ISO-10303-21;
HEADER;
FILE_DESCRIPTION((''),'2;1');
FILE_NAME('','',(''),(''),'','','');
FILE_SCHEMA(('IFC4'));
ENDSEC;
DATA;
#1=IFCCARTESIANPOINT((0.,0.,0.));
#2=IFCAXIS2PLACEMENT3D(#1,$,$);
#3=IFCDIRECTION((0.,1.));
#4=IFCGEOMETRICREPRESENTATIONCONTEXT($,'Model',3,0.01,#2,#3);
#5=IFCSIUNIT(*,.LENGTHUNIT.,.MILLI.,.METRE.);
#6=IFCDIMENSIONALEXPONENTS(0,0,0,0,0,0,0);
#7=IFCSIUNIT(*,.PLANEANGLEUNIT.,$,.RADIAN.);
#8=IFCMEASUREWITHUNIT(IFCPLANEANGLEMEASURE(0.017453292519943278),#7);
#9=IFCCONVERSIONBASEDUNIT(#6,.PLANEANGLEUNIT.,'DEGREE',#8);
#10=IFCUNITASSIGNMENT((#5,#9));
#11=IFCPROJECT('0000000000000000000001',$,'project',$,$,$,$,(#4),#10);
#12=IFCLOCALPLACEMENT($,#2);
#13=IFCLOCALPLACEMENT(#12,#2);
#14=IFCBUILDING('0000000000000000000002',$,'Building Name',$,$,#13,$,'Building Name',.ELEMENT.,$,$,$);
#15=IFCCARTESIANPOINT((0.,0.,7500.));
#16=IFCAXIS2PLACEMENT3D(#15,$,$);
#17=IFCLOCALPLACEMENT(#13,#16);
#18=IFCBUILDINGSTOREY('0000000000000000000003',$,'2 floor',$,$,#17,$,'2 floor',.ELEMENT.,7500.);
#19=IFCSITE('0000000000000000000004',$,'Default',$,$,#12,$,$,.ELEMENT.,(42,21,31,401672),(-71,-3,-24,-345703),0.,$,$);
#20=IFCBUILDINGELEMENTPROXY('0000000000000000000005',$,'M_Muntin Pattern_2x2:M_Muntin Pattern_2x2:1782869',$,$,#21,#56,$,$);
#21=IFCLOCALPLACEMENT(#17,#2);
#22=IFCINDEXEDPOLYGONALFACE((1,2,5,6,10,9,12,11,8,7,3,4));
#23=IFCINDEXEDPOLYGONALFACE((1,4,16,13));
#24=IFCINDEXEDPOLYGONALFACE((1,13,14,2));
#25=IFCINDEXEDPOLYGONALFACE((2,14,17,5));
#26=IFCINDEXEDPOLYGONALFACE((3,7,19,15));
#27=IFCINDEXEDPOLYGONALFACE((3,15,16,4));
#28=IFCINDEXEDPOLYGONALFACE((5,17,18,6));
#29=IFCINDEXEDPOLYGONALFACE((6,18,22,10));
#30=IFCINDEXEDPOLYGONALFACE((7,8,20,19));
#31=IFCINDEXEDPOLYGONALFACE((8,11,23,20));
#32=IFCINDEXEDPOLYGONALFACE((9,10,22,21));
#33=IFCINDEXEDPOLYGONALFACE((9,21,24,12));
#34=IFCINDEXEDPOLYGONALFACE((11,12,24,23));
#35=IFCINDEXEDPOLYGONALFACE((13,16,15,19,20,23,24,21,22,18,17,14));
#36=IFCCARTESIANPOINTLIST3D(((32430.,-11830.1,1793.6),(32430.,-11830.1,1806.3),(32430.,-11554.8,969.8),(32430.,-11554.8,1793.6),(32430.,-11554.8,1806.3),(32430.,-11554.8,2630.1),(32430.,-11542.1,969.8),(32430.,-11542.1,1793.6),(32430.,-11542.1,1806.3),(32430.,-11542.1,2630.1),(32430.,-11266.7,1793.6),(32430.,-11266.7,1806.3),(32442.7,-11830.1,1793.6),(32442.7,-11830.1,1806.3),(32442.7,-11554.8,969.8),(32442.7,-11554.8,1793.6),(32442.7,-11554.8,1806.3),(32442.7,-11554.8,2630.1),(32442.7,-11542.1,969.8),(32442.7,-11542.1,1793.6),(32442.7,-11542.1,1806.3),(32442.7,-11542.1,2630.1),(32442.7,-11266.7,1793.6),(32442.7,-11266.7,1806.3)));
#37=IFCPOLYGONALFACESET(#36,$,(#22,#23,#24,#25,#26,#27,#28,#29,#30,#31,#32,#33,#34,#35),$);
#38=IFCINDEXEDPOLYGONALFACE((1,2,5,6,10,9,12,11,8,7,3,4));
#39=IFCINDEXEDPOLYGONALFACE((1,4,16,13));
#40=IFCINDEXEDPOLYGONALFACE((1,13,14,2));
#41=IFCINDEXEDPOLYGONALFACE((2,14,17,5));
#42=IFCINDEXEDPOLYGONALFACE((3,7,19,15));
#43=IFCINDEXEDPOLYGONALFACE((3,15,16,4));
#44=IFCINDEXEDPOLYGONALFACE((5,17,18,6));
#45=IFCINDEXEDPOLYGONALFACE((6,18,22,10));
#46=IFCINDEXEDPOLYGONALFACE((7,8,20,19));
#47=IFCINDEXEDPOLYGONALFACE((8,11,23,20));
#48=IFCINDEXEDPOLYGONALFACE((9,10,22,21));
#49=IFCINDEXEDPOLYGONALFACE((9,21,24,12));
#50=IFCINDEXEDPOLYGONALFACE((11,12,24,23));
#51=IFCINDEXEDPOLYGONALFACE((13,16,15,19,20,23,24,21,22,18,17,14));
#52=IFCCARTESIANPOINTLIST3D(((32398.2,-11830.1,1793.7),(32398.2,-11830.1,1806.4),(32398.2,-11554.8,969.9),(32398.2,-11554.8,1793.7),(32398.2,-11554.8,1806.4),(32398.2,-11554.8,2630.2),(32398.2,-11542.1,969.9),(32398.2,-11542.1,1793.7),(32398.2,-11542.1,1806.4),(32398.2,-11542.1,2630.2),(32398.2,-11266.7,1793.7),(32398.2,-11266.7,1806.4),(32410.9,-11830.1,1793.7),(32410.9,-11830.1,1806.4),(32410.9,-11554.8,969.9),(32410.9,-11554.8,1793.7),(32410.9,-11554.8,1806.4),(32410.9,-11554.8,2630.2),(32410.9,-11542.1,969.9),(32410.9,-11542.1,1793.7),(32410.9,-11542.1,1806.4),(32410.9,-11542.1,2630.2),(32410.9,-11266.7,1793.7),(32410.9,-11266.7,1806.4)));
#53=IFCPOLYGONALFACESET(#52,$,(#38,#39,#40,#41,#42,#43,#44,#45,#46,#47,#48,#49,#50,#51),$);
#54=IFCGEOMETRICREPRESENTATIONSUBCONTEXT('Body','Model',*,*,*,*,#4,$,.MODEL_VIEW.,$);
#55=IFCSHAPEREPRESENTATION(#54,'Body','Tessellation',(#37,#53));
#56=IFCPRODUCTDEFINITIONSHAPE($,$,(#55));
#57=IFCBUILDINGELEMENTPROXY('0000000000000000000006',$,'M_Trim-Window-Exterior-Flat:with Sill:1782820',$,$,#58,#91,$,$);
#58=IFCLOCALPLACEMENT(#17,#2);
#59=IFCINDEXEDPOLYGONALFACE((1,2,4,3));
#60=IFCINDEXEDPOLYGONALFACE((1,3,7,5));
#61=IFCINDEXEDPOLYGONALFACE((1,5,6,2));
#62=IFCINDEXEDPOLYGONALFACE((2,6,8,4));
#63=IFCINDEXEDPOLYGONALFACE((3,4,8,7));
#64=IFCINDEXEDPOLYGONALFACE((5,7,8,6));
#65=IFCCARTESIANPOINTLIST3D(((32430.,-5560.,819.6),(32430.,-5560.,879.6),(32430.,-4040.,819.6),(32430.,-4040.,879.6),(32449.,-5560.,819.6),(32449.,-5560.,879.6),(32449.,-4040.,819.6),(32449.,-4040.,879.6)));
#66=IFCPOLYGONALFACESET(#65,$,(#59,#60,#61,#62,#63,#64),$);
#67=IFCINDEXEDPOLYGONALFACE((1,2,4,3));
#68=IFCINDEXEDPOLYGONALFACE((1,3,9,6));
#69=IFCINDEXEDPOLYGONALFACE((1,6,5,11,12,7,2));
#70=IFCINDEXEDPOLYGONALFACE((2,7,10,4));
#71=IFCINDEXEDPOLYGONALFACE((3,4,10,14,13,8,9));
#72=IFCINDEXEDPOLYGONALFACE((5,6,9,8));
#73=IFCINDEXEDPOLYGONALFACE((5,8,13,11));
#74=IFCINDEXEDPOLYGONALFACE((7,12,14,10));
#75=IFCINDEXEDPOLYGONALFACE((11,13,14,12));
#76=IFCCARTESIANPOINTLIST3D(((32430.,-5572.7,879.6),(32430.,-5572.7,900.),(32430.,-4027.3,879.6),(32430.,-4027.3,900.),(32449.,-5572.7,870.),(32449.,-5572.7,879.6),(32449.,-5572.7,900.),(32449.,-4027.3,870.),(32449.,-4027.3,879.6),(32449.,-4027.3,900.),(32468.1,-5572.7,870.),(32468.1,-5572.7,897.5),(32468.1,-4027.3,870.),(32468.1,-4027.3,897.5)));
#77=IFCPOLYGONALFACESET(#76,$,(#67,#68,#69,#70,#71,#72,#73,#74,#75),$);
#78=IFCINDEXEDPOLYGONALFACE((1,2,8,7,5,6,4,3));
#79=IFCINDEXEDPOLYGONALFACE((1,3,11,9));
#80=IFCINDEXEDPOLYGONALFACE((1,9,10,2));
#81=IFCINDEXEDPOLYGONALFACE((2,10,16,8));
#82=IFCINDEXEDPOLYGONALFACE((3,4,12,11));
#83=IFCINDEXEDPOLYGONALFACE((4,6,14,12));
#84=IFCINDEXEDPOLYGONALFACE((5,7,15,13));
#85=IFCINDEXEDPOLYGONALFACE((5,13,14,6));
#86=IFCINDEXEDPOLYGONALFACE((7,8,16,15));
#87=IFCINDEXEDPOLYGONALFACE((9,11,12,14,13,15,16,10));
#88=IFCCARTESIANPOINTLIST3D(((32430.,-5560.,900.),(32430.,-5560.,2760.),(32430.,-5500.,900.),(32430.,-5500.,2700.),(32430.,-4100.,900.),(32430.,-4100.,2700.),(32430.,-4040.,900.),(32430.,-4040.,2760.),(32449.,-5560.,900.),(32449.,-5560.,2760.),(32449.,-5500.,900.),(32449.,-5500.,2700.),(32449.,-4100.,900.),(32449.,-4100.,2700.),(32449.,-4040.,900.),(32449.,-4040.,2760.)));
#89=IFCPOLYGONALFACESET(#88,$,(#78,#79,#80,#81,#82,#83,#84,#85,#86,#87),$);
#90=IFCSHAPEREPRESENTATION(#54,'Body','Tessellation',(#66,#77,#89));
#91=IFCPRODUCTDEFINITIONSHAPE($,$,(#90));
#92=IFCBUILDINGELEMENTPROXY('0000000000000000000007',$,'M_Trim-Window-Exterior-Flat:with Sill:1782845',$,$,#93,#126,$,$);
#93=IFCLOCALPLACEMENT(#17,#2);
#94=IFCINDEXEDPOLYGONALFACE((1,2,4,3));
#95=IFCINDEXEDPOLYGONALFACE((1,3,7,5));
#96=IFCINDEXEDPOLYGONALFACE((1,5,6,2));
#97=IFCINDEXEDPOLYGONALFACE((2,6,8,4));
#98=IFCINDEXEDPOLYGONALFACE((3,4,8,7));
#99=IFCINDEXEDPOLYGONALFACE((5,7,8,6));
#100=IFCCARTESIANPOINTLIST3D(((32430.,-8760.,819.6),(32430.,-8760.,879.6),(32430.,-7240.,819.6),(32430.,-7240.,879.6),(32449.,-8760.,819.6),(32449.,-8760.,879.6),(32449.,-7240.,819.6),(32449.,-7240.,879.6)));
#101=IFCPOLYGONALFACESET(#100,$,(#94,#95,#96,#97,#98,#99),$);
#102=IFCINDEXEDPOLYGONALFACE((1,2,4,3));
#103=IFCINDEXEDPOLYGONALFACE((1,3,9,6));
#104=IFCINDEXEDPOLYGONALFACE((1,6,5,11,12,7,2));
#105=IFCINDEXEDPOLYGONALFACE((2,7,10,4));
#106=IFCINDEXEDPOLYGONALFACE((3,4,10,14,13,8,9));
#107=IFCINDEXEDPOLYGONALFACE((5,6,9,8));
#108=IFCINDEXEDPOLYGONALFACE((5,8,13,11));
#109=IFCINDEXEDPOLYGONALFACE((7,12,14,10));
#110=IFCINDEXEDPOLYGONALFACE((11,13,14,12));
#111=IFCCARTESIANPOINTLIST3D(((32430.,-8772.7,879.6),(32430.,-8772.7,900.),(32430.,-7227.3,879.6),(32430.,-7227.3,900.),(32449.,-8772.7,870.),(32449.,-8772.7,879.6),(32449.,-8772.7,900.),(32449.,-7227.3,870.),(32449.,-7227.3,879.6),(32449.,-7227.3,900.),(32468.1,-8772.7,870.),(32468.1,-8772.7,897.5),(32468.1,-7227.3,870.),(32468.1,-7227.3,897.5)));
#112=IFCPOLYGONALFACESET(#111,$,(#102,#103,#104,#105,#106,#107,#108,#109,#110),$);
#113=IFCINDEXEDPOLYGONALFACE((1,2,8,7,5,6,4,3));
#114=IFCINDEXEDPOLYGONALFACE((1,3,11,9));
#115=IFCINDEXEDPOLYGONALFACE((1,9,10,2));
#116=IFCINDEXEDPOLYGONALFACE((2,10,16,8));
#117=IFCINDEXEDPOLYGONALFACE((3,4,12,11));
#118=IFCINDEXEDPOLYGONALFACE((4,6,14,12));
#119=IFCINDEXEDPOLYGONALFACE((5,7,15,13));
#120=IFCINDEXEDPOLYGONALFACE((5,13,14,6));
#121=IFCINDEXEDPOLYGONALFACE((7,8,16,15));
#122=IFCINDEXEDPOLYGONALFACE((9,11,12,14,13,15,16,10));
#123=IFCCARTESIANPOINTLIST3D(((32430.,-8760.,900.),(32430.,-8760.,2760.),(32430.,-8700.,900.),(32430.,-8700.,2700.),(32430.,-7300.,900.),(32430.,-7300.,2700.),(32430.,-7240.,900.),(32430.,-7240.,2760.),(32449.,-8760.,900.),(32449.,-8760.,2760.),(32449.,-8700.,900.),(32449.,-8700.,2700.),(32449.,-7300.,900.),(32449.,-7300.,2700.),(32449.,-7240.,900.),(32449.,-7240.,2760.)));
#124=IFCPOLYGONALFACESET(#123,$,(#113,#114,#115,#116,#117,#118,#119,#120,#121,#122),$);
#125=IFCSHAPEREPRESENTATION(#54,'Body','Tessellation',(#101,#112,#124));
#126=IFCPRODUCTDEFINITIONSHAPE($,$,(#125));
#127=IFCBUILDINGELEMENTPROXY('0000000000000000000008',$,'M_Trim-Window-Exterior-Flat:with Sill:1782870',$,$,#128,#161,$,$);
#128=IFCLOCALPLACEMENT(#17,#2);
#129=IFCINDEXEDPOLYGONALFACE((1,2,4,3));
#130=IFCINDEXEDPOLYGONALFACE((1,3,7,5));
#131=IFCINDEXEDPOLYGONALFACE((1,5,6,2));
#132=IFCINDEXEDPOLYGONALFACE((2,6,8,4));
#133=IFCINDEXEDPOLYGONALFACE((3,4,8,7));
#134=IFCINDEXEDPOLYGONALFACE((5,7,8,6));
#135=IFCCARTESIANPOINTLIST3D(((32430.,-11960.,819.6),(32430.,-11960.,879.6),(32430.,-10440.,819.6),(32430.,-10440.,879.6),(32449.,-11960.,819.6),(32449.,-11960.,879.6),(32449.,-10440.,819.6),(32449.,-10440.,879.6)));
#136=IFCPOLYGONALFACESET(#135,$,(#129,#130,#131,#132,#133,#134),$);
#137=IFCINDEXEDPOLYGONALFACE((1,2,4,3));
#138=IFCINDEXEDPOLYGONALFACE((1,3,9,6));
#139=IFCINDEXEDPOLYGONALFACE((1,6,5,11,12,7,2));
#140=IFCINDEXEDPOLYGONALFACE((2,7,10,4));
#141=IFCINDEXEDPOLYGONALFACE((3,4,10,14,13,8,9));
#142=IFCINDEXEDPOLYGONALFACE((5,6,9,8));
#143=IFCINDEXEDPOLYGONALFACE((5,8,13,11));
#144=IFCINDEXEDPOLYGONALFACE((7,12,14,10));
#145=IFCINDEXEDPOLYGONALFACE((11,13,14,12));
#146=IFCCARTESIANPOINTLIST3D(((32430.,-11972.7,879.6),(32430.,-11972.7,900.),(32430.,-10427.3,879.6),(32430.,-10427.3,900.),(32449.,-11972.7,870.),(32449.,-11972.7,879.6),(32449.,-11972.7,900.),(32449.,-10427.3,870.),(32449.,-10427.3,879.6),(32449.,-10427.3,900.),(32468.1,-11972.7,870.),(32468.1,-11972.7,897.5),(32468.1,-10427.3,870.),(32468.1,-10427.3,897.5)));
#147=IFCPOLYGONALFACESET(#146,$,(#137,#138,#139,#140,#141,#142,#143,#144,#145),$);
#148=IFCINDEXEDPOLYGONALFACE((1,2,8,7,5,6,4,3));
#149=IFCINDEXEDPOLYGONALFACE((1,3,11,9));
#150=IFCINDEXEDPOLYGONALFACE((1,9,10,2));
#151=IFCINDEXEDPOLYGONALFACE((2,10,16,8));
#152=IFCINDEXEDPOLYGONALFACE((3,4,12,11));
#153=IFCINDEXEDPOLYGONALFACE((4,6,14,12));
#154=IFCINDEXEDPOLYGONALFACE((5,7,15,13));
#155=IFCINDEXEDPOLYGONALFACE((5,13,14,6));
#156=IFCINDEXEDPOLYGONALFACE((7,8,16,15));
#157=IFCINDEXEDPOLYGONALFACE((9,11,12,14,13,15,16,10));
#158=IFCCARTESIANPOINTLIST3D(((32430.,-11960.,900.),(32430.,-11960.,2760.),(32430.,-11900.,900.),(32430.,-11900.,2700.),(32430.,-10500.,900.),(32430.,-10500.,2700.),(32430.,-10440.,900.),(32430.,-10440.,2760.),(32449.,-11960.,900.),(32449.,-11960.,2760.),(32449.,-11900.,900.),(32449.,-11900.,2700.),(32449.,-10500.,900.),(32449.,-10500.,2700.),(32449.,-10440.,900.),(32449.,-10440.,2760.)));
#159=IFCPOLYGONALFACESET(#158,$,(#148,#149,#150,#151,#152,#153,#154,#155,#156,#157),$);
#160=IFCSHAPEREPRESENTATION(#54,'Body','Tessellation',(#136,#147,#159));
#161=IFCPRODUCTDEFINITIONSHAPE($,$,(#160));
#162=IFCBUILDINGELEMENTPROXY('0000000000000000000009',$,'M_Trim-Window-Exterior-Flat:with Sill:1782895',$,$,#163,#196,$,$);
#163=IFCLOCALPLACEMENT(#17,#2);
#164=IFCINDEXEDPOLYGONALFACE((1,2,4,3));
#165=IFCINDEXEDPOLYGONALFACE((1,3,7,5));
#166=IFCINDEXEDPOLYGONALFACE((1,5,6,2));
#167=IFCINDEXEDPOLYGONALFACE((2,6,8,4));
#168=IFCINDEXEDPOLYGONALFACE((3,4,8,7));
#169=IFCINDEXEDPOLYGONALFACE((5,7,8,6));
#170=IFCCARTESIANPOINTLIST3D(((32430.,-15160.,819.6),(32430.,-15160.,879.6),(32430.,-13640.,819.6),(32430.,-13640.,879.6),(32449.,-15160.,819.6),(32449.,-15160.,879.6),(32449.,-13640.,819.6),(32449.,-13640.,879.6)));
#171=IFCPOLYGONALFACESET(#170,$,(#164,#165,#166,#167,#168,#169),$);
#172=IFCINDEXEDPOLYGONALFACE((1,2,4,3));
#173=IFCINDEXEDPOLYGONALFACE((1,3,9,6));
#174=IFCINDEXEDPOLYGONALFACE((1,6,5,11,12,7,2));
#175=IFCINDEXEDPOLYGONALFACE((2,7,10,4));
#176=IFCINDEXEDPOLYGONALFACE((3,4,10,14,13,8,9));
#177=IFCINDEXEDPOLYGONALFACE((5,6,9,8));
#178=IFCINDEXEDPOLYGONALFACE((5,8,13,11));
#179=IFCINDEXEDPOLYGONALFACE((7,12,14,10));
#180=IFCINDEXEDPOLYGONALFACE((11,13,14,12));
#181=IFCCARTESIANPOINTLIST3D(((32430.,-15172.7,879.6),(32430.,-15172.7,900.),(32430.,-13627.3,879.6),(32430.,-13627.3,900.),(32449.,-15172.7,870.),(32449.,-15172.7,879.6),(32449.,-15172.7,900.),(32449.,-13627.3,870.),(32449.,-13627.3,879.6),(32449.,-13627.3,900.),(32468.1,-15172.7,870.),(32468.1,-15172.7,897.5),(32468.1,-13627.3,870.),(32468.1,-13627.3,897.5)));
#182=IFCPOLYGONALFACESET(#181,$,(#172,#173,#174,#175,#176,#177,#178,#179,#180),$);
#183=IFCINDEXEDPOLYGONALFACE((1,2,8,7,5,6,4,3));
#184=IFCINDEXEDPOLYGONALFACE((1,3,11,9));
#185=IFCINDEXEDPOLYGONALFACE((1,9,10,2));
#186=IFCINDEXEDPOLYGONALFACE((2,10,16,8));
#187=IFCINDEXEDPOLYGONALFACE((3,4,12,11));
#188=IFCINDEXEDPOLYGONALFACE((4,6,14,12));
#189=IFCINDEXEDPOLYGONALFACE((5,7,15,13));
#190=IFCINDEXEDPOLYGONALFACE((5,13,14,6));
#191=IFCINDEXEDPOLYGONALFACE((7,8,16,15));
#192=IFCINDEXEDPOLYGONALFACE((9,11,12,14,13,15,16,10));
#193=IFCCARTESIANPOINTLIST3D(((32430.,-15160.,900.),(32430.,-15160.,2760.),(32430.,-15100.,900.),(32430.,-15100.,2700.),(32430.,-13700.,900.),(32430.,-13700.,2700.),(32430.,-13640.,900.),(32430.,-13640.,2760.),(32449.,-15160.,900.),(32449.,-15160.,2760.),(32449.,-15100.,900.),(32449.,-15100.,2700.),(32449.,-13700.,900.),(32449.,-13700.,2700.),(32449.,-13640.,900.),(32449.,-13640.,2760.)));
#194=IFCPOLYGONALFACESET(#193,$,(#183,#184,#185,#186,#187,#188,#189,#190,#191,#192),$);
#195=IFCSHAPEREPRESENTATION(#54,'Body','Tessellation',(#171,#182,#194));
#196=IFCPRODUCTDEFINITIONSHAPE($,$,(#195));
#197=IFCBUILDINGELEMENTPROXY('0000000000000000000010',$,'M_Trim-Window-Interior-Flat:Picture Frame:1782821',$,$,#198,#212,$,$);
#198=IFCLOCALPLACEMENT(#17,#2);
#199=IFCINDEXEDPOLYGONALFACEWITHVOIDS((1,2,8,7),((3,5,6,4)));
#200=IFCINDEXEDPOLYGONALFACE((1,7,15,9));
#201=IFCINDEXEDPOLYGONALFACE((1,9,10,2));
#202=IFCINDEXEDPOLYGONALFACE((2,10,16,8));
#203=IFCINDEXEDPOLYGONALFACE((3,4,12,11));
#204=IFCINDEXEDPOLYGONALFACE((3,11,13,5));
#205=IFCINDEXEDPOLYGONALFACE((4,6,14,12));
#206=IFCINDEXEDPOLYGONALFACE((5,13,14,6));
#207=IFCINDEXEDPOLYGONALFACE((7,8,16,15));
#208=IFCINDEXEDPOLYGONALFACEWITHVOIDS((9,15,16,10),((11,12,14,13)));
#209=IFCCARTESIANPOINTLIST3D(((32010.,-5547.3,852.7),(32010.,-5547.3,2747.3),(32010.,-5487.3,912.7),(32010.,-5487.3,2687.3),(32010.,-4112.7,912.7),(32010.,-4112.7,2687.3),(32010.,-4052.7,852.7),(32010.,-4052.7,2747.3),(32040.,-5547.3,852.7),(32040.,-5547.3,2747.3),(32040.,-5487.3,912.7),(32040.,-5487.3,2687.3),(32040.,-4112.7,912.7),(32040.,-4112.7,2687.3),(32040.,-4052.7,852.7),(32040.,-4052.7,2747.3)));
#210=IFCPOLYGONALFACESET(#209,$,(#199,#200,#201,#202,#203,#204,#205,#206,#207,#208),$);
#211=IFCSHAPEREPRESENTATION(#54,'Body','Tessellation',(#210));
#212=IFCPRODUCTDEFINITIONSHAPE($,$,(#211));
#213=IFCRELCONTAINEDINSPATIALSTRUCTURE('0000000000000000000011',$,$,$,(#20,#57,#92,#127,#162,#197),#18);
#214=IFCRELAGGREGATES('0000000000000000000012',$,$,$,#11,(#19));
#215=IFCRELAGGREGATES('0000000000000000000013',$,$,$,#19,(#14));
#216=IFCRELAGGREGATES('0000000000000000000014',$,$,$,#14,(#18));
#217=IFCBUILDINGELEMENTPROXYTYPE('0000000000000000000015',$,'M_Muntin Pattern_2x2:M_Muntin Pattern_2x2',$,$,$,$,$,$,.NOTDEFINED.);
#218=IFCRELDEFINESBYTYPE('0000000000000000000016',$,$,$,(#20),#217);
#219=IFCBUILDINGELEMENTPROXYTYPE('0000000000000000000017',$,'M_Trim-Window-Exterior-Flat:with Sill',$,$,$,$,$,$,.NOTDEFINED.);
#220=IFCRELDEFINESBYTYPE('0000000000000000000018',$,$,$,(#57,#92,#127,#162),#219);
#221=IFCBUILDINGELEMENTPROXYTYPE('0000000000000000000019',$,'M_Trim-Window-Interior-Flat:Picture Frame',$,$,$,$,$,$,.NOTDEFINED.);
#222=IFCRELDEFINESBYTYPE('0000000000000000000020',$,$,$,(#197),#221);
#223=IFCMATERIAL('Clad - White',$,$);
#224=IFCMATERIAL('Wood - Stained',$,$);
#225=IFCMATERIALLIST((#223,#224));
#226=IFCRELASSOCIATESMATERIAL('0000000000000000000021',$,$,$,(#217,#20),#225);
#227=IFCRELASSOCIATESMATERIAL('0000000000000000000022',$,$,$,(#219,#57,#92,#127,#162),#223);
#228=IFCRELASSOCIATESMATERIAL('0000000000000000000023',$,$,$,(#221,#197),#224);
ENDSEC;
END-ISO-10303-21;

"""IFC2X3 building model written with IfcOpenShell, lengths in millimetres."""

from ifc_helpers import new_model, entity, si_unit, converted_unit, direction, frame, frame_2d, origin, place, context, subcontext, project, spatial, polyline, rectangle, outline, extrude, source, transform, mapped, material, material_list, type_object, type_shapes, element, save


model = new_model("IFC2X3")

# Units and contexts
model_context = context("Model", 3, precision=0.01, world=origin(), true_north=direction((0.0, 1.0)))
body_context = subcontext(model_context, "Body", "Model", "MODEL_VIEW")
ifc_project = project(units=[si_unit("LENGTHUNIT", "METRE", prefix="MILLI"), converted_unit("PLANEANGLEUNIT", "DEGREE", entity("IfcPlaneAngleMeasure", 0.017453292519943278), si_unit("PLANEANGLEUNIT", "RADIAN"), dimensions=[0, 0, 0, 0, 0, 0, 0])], contexts=[model_context])

# Site, building, storey
site_placement = place(None, origin())
site = spatial("IfcSite", under=ifc_project, at=site_placement, Name="Default", CompositionType="ELEMENT", RefLatitude=(42, 21, 31, 401672), RefLongitude=(-71, -3, -24, -345703), RefElevation=0.0)
building_placement = place(site_placement, origin())
building = spatial("IfcBuilding", under=site, at=building_placement, Name="Building Name", LongName="Building Name", CompositionType="ELEMENT")
storey_placement = place(building_placement, frame((0.0, 0.0, 7500.0)))
storey = spatial("IfcBuildingStorey", under=building, at=storey_placement, Name="2 floor", LongName="2 floor", CompositionType="ELEMENT", Elevation=7500.0)

# Building element proxies
ifc_material_1 = material(Name="Clad - White")
ifc_material_2 = material(Name="Wood - Stained")
ifc_material_list = material_list([ifc_material_1, ifc_material_2])
building_element_proxy_type_1 = type_object("IfcBuildingElementProxyType", Name="M_Muntin Pattern_2x2:M_Muntin Pattern_2x2", PredefinedType="NOTDEFINED", material=ifc_material_list)
shared_shape_1 = source(origin(), body_context, "Body", "SweptSolid", [
    extrude(outline(polyline([(6.4, -6.4), (830.1, -6.4), (830.1, 6.3), (6.4, 6.3), (6.4, 281.7), (-6.3, 281.7), (-6.3, 6.3), (-830.2, 6.3), (-830.2, -6.4), (-6.3, -6.4), (-6.3, -281.7), (6.4, -281.7), (6.4, -6.4)])), frame((0.0, -22.2, 830.1), z_axis=(0.0, 1.0, 0.0), x_axis=(0.0, 0.0, 1.0)), (0.0, 0.0, 1.0), 12.7),
    extrude(outline(polyline([(6.4, -6.4), (830.2, -6.4), (830.2, 6.3), (6.4, 6.3), (6.4, 281.7), (-6.3, 281.7), (-6.3, 6.3), (-830.2, 6.3), (-830.2, -6.4), (-6.3, -6.4), (-6.3, -281.7), (6.4, -281.7), (6.4, -6.4)])), frame((0.0, 9.5, 830.2), z_axis=(0.0, 1.0, 0.0), x_axis=(0.0, 0.0, 1.0)), (0.0, 0.0, 1.0), 12.7),
])
type_shapes(building_element_proxy_type_1, [shared_shape_1])
for number, where, z_axis, x_axis, name in (
    (1, (32420.5, -11548.4, 969.9), (0.0, 0.0, 1.0), (0.0, 1.0, 0.0), "M_Muntin Pattern_2x2:M_Muntin Pattern_2x2:1782869"),
):
    element("IfcBuildingElementProxy", number, at=place(storey_placement, frame(where, z_axis=z_axis, x_axis=x_axis)), inside=storey, type_object=building_element_proxy_type_1, material=ifc_material_list, Name=name, context=body_context, shape_type="MappedRepresentation", body=[
        mapped(shared_shape_1, transform((0.0, 0.0, 0.0), scale=1.0)),
    ])
building_element_proxy_type_2 = type_object("IfcBuildingElementProxyType", Name="M_Trim-Window-Exterior-Flat:with Sill", PredefinedType="NOTDEFINED", material=ifc_material_1)
shared_shape_2 = source(origin(), body_context, "Body", "SweptSolid", [
    extrude(rectangle(XDim=1520.0, YDim=60.0, at=frame_2d((0.0, 0.0), x_axis=(1.0, 0.0))), frame((0.0, -1850.4, 0.0), z_axis=(0.0, 0.0, 1.0), x_axis=(-1.0, 0.0, 0.0)), (0.0, 0.0, 1.0), 19.0),
    extrude(outline(polyline([(-19.0, -15.2), (0.0, -15.2), (0.0, -5.7), (19.0, -5.7), (19.0, 14.8), (0.0, 14.8), (-19.0, 12.3), (-19.0, -15.2)])), frame((-772.7, -1814.8, 19.0), z_axis=(1.0, 0.0, 0.0), x_axis=(0.0, 0.0, -1.0)), (0.0, 0.0, 1.0), 1545.4),
    extrude(outline(polyline([(-945.0, -760.0), (915.0, -760.0), (915.0, -700.0), (-885.0, -700.0), (-885.0, 700.0), (915.0, 700.0), (915.0, 760.0), (-945.0, 760.0), (-945.0, -760.0)])), frame((0.0, -885.0, 0.0), z_axis=(0.0, 0.0, 1.0), x_axis=(0.0, -1.0, 0.0)), (0.0, 0.0, 1.0), 19.0),
])
type_shapes(building_element_proxy_type_2, [shared_shape_2])
for number, where, z_axis, x_axis, name in (
    (2, (32430.0, -4800.0, 2700.0), (1.0, 0.0, 0.0), (0.0, 1.0, 0.0), "M_Trim-Window-Exterior-Flat:with Sill:1782820"),
    (3, (32430.0, -8000.0, 2700.0), (1.0, 0.0, 0.0), (0.0, 1.0, 0.0), "M_Trim-Window-Exterior-Flat:with Sill:1782845"),
    (4, (32430.0, -11200.0, 2700.0), (1.0, 0.0, 0.0), (0.0, 1.0, 0.0), "M_Trim-Window-Exterior-Flat:with Sill:1782870"),
    (5, (32430.0, -14400.0, 2700.0), (1.0, 0.0, 0.0), (0.0, 1.0, 0.0), "M_Trim-Window-Exterior-Flat:with Sill:1782895"),
):
    element("IfcBuildingElementProxy", number, at=place(storey_placement, frame(where, z_axis=z_axis, x_axis=x_axis)), inside=storey, type_object=building_element_proxy_type_2, material=ifc_material_1, Name=name, context=body_context, shape_type="MappedRepresentation", body=[
        mapped(shared_shape_2, transform((0.0, 0.0, 0.0), scale=1.0)),
    ])
building_element_proxy_type_3 = type_object("IfcBuildingElementProxyType", Name="M_Trim-Window-Interior-Flat:Picture Frame", PredefinedType="NOTDEFINED", material=ifc_material_2)
shared_shape_3 = source(origin(), body_context, "Body", "SweptSolid", [
    extrude(outline(polyline([(-747.3, -947.3), (747.3, -947.3), (747.3, 947.3), (-747.3, 947.3), (-747.3, -947.3)]), holes=[polyline([(-687.3, -887.3), (-687.3, 887.3), (687.3, 887.3), (687.3, -887.3), (-687.3, -887.3)])]), frame((0.0, -900.0, 0.0), z_axis=(0.0, 0.0, 1.0), x_axis=(-1.0, 0.0, 0.0)), (0.0, 0.0, 1.0), 30.0),
])
type_shapes(building_element_proxy_type_3, [shared_shape_3])
for number, where, z_axis, x_axis, name in (
    (6, (32040.0, -4800.0, 2700.0), (-1.0, 0.0, 0.0), (0.0, -1.0, 0.0), "M_Trim-Window-Interior-Flat:Picture Frame:1782821"),
):
    element("IfcBuildingElementProxy", number, at=place(storey_placement, frame(where, z_axis=z_axis, x_axis=x_axis)), inside=storey, type_object=building_element_proxy_type_3, material=ifc_material_2, Name=name, context=body_context, shape_type="MappedRepresentation", body=[
        mapped(shared_shape_3, transform((0.0, 0.0, 0.0), scale=1.0)),
    ])

save(model, "model.ifc")
